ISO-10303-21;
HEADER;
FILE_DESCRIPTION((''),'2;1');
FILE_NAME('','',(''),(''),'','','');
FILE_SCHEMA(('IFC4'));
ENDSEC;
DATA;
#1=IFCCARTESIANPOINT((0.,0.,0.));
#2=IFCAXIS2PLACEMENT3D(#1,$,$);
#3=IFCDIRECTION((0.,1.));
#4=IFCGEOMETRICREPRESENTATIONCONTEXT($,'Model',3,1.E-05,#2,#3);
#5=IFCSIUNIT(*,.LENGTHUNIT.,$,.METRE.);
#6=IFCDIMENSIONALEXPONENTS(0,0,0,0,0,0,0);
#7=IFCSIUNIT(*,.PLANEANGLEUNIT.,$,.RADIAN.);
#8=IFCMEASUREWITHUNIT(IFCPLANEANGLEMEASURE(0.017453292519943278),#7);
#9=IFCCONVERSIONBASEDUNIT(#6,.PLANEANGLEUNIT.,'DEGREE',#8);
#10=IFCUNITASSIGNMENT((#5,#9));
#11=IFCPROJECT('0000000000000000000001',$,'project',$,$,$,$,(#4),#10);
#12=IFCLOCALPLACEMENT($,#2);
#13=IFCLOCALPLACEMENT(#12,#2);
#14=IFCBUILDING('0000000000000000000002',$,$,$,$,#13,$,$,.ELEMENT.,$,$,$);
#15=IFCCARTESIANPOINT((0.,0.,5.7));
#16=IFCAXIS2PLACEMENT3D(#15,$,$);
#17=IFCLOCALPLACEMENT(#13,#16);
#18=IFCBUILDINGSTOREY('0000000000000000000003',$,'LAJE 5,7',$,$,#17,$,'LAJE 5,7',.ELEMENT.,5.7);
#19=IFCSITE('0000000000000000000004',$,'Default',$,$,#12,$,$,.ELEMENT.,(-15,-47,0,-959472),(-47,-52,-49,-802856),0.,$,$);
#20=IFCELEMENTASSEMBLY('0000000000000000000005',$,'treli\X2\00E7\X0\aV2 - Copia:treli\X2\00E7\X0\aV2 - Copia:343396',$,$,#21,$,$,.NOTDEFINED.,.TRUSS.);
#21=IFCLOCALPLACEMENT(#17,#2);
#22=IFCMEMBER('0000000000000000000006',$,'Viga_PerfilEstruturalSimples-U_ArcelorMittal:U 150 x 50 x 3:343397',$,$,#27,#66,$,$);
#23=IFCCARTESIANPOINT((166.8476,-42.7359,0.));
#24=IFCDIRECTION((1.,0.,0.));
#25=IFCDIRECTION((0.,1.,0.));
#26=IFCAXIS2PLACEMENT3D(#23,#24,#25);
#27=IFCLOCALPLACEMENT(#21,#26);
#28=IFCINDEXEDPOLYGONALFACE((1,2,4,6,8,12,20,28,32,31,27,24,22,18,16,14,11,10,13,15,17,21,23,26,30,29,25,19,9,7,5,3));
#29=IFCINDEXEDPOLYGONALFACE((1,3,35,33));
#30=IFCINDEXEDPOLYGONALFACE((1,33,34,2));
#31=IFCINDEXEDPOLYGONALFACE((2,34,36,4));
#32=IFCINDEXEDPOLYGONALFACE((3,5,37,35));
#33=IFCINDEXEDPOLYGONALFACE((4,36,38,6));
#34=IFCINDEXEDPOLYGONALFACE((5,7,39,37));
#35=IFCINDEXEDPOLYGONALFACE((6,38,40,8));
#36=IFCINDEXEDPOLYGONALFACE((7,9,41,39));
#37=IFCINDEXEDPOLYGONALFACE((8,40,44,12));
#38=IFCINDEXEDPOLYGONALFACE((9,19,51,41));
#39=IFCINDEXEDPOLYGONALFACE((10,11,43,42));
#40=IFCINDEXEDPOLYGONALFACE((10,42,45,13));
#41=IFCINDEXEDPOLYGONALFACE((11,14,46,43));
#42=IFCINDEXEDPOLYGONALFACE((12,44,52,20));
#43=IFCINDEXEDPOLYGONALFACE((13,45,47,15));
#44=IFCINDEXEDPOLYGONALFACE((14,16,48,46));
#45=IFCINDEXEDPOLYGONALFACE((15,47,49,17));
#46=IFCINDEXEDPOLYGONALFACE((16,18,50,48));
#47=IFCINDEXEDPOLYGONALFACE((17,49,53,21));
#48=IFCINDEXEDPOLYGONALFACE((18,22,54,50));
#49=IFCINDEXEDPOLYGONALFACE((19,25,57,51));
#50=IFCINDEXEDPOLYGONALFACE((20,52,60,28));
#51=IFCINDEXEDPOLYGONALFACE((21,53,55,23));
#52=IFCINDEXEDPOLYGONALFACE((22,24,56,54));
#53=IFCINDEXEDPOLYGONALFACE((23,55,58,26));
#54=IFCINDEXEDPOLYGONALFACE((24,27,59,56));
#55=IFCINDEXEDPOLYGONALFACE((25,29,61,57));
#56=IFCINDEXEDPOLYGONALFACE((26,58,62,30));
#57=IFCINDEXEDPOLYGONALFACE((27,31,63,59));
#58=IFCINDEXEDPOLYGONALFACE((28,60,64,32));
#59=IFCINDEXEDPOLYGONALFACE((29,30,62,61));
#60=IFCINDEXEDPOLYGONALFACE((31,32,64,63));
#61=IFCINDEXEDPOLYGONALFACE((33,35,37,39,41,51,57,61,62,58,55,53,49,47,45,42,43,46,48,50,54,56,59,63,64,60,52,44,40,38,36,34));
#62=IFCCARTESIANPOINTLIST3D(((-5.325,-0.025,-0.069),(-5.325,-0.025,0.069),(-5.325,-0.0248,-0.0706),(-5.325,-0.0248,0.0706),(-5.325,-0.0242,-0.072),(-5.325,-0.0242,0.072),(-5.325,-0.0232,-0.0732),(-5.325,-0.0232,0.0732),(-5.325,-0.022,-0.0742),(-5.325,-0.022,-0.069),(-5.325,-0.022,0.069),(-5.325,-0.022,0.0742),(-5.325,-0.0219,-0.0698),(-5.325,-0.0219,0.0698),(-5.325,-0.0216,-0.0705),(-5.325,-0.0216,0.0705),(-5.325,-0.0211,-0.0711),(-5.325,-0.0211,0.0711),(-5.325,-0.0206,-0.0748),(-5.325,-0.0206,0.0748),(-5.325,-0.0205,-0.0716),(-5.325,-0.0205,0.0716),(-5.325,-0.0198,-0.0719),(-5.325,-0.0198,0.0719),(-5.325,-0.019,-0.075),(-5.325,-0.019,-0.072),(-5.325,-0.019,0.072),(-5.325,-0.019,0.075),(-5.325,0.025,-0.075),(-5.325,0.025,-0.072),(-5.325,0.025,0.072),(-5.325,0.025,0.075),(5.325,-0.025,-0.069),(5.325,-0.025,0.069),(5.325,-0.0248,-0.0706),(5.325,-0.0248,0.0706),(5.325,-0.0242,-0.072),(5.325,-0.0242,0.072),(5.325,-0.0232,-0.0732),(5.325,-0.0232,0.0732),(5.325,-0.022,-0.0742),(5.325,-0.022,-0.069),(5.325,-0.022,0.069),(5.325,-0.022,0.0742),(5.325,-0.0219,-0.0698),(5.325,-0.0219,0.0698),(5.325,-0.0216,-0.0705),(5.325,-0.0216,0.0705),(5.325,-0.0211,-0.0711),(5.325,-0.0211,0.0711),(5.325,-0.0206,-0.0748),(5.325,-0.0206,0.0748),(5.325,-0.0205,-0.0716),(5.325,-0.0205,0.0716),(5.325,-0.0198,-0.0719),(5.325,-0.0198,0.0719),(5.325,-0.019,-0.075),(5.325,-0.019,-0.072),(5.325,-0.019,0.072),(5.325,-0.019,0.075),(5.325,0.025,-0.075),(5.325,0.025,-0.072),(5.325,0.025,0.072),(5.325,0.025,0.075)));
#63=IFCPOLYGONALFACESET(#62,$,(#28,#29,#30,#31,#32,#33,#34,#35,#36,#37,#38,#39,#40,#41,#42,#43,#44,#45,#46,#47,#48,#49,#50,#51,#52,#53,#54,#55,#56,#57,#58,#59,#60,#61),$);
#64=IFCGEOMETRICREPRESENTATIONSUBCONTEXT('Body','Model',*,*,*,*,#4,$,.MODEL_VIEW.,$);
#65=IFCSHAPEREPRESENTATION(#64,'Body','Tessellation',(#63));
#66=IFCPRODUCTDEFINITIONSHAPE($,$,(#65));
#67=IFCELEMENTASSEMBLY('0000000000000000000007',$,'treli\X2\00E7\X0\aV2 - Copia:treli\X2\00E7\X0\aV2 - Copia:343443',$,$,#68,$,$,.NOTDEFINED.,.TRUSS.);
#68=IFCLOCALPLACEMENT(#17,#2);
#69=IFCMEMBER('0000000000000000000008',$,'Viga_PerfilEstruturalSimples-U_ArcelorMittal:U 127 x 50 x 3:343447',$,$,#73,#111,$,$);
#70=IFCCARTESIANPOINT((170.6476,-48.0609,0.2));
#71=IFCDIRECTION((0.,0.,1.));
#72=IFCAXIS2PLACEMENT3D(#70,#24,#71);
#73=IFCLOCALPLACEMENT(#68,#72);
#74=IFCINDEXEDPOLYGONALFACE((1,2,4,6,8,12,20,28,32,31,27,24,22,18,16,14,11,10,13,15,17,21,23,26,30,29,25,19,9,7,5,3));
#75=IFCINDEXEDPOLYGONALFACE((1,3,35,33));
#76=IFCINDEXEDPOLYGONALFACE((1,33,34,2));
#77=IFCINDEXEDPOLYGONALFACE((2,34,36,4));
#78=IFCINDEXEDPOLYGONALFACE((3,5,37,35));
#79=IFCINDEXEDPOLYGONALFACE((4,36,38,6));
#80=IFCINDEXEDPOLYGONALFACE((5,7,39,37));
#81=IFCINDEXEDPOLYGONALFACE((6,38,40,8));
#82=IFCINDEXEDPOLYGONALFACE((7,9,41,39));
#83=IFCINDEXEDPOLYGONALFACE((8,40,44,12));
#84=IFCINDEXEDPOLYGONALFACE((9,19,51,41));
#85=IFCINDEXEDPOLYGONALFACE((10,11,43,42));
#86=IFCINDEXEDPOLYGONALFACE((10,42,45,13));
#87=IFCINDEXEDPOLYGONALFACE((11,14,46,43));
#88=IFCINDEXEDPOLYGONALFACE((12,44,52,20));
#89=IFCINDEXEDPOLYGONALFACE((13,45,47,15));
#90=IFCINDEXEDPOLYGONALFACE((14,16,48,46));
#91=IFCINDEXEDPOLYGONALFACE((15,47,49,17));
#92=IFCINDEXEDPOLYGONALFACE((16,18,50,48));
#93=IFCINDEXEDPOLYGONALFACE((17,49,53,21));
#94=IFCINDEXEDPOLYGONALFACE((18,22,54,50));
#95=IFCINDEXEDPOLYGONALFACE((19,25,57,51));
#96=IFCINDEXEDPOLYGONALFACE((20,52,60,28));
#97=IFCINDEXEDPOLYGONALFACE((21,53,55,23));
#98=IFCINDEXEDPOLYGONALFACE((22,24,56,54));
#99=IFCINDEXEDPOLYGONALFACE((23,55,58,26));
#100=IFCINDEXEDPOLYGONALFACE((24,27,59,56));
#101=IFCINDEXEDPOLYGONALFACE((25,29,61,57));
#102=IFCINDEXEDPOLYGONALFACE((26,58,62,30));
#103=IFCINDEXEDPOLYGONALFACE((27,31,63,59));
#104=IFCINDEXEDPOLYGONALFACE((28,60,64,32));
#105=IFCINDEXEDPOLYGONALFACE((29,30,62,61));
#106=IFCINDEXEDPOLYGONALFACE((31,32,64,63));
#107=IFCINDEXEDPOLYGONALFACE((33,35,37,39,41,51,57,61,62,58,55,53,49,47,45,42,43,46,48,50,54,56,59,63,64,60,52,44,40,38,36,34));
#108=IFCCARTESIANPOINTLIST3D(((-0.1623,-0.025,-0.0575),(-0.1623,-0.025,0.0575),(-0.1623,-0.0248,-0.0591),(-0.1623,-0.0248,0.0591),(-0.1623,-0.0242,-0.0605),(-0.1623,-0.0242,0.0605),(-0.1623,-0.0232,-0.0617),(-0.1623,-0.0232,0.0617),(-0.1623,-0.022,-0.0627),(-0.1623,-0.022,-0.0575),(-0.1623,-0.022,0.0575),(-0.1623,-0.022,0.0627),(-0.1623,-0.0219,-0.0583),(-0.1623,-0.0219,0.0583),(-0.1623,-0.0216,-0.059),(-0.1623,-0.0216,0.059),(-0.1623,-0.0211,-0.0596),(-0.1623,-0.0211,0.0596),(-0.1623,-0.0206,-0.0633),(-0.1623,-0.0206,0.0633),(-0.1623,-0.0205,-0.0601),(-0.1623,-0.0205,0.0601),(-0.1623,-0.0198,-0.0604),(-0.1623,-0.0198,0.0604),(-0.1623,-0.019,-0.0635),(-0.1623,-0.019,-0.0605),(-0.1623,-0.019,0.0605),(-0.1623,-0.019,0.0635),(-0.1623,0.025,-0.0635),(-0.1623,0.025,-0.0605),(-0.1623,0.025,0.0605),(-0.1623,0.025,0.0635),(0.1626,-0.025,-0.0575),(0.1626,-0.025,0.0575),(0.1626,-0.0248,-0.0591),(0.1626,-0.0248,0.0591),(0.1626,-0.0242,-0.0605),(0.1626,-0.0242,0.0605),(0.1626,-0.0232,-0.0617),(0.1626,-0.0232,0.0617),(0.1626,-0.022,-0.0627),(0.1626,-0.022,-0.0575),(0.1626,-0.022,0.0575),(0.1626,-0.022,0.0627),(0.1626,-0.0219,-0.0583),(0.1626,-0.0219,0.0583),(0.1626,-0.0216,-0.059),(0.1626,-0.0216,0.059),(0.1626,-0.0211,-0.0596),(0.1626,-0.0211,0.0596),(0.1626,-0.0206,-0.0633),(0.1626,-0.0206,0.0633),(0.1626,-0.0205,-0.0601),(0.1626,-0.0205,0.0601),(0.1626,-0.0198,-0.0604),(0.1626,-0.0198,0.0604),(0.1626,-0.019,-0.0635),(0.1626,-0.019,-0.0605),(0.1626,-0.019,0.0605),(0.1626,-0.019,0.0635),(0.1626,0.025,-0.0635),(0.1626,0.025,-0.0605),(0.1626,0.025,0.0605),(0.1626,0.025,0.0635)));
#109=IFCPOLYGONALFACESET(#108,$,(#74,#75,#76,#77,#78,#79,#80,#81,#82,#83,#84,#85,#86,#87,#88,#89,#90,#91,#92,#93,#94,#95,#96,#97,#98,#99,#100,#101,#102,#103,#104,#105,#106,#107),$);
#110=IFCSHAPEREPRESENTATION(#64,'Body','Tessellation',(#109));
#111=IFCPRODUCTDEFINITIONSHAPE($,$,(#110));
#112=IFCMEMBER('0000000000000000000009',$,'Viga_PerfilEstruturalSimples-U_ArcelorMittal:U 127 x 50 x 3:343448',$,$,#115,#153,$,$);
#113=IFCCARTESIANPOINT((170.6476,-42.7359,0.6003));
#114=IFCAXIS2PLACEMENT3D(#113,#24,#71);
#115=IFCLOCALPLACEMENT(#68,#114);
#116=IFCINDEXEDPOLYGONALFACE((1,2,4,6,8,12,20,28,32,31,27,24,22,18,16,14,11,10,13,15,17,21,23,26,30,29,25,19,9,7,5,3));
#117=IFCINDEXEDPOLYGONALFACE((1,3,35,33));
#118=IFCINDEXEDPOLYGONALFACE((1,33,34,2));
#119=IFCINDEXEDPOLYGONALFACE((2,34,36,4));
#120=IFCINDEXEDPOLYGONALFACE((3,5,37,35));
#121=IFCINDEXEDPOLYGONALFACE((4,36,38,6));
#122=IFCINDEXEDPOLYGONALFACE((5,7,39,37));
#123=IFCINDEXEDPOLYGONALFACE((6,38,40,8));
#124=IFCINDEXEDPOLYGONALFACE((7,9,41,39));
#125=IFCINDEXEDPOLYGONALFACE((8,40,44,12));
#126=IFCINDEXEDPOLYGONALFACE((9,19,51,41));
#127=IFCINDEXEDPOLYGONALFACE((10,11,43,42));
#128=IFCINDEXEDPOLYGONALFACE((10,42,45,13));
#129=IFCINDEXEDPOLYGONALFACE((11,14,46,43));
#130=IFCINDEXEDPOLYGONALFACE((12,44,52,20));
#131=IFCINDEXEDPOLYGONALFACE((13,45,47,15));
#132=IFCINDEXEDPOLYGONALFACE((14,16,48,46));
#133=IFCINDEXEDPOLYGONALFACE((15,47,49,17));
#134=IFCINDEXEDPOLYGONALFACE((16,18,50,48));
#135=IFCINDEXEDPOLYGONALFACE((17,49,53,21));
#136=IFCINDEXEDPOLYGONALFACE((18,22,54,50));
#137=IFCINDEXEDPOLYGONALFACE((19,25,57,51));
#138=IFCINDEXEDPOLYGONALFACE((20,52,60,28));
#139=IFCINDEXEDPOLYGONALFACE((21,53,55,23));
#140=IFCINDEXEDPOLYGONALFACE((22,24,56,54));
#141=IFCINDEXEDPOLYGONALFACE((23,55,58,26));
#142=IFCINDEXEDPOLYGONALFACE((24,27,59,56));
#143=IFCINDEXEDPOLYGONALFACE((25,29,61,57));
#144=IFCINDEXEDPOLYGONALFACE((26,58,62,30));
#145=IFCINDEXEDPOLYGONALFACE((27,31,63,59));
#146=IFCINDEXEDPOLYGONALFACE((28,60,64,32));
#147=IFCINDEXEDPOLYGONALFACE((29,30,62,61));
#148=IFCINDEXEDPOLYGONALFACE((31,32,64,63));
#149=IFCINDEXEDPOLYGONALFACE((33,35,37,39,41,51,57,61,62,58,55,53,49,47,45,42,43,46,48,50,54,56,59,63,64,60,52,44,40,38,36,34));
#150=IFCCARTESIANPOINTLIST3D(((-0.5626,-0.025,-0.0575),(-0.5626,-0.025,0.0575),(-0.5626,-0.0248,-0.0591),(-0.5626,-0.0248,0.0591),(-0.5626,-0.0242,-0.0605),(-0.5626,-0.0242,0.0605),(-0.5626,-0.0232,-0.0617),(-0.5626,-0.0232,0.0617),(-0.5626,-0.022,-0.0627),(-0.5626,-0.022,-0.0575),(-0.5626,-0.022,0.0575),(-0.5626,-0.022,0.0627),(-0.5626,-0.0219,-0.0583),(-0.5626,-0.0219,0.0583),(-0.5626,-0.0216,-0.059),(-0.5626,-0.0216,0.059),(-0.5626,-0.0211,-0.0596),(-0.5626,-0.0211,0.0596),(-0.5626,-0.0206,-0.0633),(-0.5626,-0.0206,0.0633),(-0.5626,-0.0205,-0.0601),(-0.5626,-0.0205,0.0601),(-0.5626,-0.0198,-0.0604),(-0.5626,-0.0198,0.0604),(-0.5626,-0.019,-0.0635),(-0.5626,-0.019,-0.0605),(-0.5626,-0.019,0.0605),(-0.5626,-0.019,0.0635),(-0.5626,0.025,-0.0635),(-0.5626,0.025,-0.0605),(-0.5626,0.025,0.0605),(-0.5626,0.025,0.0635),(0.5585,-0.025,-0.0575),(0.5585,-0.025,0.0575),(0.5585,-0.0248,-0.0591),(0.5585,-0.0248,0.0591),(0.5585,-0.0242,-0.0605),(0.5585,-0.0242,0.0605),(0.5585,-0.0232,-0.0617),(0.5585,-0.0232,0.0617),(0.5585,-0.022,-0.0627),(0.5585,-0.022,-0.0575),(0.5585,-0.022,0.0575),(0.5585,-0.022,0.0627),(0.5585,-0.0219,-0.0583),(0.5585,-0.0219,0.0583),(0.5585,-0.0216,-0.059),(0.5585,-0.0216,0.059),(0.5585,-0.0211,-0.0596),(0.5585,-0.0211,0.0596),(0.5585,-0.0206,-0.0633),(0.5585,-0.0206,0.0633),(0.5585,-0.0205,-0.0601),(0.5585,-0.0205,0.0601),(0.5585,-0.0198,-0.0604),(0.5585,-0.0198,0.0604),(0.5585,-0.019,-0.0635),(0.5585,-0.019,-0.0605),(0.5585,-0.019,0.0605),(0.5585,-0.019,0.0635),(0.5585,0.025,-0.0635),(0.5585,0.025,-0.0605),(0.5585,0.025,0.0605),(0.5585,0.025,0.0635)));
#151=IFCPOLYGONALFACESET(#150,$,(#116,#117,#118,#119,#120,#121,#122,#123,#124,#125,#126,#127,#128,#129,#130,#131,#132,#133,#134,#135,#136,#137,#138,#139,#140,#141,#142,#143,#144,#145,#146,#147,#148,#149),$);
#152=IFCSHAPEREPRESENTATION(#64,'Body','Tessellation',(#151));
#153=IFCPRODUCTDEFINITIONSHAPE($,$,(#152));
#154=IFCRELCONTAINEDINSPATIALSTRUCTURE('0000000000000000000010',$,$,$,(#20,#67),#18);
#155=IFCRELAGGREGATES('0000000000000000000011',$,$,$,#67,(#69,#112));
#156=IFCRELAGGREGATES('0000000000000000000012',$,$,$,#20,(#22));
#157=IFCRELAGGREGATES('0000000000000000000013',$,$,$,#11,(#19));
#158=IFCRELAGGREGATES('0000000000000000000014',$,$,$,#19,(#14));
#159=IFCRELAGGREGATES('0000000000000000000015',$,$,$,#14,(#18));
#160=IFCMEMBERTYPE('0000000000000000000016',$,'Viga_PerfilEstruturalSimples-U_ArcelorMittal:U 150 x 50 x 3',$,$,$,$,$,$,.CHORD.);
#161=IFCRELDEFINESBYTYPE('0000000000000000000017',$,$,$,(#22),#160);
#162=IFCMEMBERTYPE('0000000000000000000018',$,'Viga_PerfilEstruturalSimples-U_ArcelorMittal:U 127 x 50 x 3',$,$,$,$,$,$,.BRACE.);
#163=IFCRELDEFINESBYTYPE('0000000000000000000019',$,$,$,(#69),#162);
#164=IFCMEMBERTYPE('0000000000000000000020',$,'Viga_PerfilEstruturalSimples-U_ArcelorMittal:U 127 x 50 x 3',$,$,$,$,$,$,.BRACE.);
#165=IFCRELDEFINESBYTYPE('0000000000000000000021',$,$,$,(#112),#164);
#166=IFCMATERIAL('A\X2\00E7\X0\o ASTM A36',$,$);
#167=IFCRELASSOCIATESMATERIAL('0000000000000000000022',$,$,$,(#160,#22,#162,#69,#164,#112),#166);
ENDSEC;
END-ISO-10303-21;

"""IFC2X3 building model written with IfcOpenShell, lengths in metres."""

from ifc_helpers import new_model, entity, si_unit, converted_unit, direction, frame, frame_2d, origin, place, context, subcontext, project, spatial, polyline, circle_curve, parameter, trimmed, segment, composite_curve, outline, extrude, source, transform, mapped, material, type_object, type_shapes, element, aggregate, save


model = new_model("IFC2X3")

# Units and contexts
model_context = context("Model", 3, precision=1e-05, world=origin(), true_north=direction((0.0, 1.0)))
body_context = subcontext(model_context, "Body", "Model", "MODEL_VIEW")
ifc_project = project(units=[si_unit("LENGTHUNIT", "METRE"), converted_unit("PLANEANGLEUNIT", "DEGREE", entity("IfcPlaneAngleMeasure", 0.017453292519943278), si_unit("PLANEANGLEUNIT", "RADIAN"), dimensions=[0, 0, 0, 0, 0, 0, 0])], contexts=[model_context])

# Site, building, storey
site_placement = place(None, origin())
site = spatial("IfcSite", under=ifc_project, at=site_placement, Name="Default", CompositionType="ELEMENT", RefLatitude=(-15, -47, 0, -959472), RefLongitude=(-47, -52, -49, -802856), RefElevation=0.0)
building_placement = place(site_placement, origin())
building = spatial("IfcBuilding", under=site, at=building_placement, CompositionType="ELEMENT")
storey_placement = place(building_placement, frame((0.0, 0.0, 5.7)))
storey = spatial("IfcBuildingStorey", under=building, at=storey_placement, Name="LAJE 5,7", LongName="LAJE 5,7", CompositionType="ELEMENT", Elevation=5.7)

# Element assemblies, member
assembly_1_placement = place(storey_placement, origin())
assembly_1 = element("IfcElementAssembly", 1, at=assembly_1_placement, inside=storey, Name="treliçaV2 - Copia:treliçaV2 - Copia:343396", AssemblyPlace="NOTDEFINED", PredefinedType="TRUSS")
ifc_material = material(Name="Aço ASTM A36")
member_type_1 = type_object("IfcMemberType", Name="Viga_PerfilEstruturalSimples-U_ArcelorMittal:U 150 x 50 x 3", PredefinedType="CHORD", material=ifc_material)
shared_shape_1 = source(origin(), body_context, "Body", "SweptSolid", [
    extrude(outline(composite_curve([segment(polyline([(-0.069, -0.0192), (0.069, -0.0192)]), True, "CONTINUOUS"), segment(trimmed(circle_curve(frame_2d((0.069, -0.0132), x_axis=(0.0, 1.0)), 0.006), [parameter(180.0)], [parameter(270.0)], True, "PARAMETER"), True, "CONTINUOUS"), segment(polyline([(0.075, -0.0132), (0.075, 0.0308)]), True, "CONTINUOUS"), segment(polyline([(0.075, 0.0308), (0.072, 0.0308)]), True, "CONTINUOUS"), segment(polyline([(0.072, 0.0308), (0.072, -0.0132)]), True, "CONTINUOUS"), segment(trimmed(circle_curve(frame_2d((0.069, -0.0132), x_axis=(0.0, 1.0)), 0.003), [parameter(180.0)], [parameter(270.0)], True, "PARAMETER"), False, "CONTINUOUS"), segment(polyline([(0.069, -0.0162), (-0.069, -0.0162)]), True, "CONTINUOUS"), segment(trimmed(circle_curve(frame_2d((-0.069, -0.0132), x_axis=(0.0, 1.0)), 0.003), [parameter(90.0)], [parameter(180.0)], True, "PARAMETER"), False, "CONTINUOUS"), segment(polyline([(-0.072, -0.0132), (-0.072, 0.0308)]), True, "CONTINUOUS"), segment(polyline([(-0.072, 0.0308), (-0.075, 0.0308)]), True, "CONTINUOUS"), segment(polyline([(-0.075, 0.0308), (-0.075, -0.0132)]), True, "CONTINUOUS"), segment(trimmed(circle_curve(frame_2d((-0.069, -0.0132), x_axis=(0.0, 1.0)), 0.006), [parameter(90.0)], [parameter(180.0)], True, "PARAMETER"), True, "CONTINUOUS")], self_intersect=False)), frame((-5.325, -0.0058, 0.0), z_axis=(1.0, 0.0, 0.0), x_axis=(0.0, 0.0, -1.0)), (0.0, 0.0, 1.0), 10.65),
])
type_shapes(member_type_1, [shared_shape_1])
member_1_placement = place(assembly_1_placement, frame((166.8476, -42.7359, 0.0), z_axis=(1.0, 0.0, 0.0), x_axis=(0.0, 1.0, 0.0)))
member_1 = element("IfcMember", 2, at=member_1_placement, type_object=member_type_1, material=ifc_material, Name="Viga_PerfilEstruturalSimples-U_ArcelorMittal:U 150 x 50 x 3:343397", context=body_context, shape_type="MappedRepresentation", body=[
    mapped(shared_shape_1, transform((0.0, 0.0, 0.0), scale=1.0)),
])
assembly_2_placement = place(storey_placement, origin())
assembly_2 = element("IfcElementAssembly", 3, at=assembly_2_placement, inside=storey, Name="treliçaV2 - Copia:treliçaV2 - Copia:343443", AssemblyPlace="NOTDEFINED", PredefinedType="TRUSS")

# Members
member_type_2 = type_object("IfcMemberType", Name="Viga_PerfilEstruturalSimples-U_ArcelorMittal:U 127 x 50 x 3", PredefinedType="BRACE", material=ifc_material)
shared_shape_2 = source(origin(), body_context, "Body", "SweptSolid", [
    extrude(outline(composite_curve([segment(polyline([(-0.0575, -0.0192), (0.0575, -0.0192)]), True, "CONTINUOUS"), segment(trimmed(circle_curve(frame_2d((0.0575, -0.0132), x_axis=(0.0, 1.0)), 0.006), [parameter(180.0)], [parameter(270.0)], True, "PARAMETER"), True, "CONTINUOUS"), segment(polyline([(0.0635, -0.0132), (0.0635, 0.0308)]), True, "CONTINUOUS"), segment(polyline([(0.0635, 0.0308), (0.0605, 0.0308)]), True, "CONTINUOUS"), segment(polyline([(0.0605, 0.0308), (0.0605, -0.0132)]), True, "CONTINUOUS"), segment(trimmed(circle_curve(frame_2d((0.0575, -0.0132), x_axis=(0.0, 1.0)), 0.003), [parameter(180.0)], [parameter(270.0)], True, "PARAMETER"), False, "CONTINUOUS"), segment(polyline([(0.0575, -0.0162), (-0.0575, -0.0162)]), True, "CONTINUOUS"), segment(trimmed(circle_curve(frame_2d((-0.0575, -0.0132), x_axis=(0.0, 1.0)), 0.003), [parameter(90.0)], [parameter(180.0)], True, "PARAMETER"), False, "CONTINUOUS"), segment(polyline([(-0.0605, -0.0132), (-0.0605, 0.0308)]), True, "CONTINUOUS"), segment(polyline([(-0.0605, 0.0308), (-0.0635, 0.0308)]), True, "CONTINUOUS"), segment(polyline([(-0.0635, 0.0308), (-0.0635, -0.0132)]), True, "CONTINUOUS"), segment(trimmed(circle_curve(frame_2d((-0.0575, -0.0132), x_axis=(0.0, 1.0)), 0.006), [parameter(90.0)], [parameter(180.0)], True, "PARAMETER"), True, "CONTINUOUS")], self_intersect=False)), frame((-0.1623, -0.0058, 0.0), z_axis=(1.0, 0.0, 0.0), x_axis=(0.0, 0.0, -1.0)), (0.0, 0.0, 1.0), 0.3249),
])
type_shapes(member_type_2, [shared_shape_2])
member_2_placement = place(assembly_2_placement, frame((170.6476, -48.0609, 0.2), z_axis=(1.0, 0.0, 0.0), x_axis=(0.0, 0.0, 1.0)))
member_2 = element("IfcMember", 4, at=member_2_placement, type_object=member_type_2, material=ifc_material, Name="Viga_PerfilEstruturalSimples-U_ArcelorMittal:U 127 x 50 x 3:343447", context=body_context, shape_type="MappedRepresentation", body=[
    mapped(shared_shape_2, transform((0.0, 0.0, 0.0), scale=1.0)),
])
member_type_3 = type_object("IfcMemberType", Name="Viga_PerfilEstruturalSimples-U_ArcelorMittal:U 127 x 50 x 3", PredefinedType="BRACE", material=ifc_material)
shared_shape_3 = source(origin(), body_context, "Body", "SweptSolid", [
    extrude(outline(composite_curve([segment(polyline([(-0.0575, -0.0192), (0.0575, -0.0192)]), True, "CONTINUOUS"), segment(trimmed(circle_curve(frame_2d((0.0575, -0.0132), x_axis=(0.0, 1.0)), 0.006), [parameter(180.0)], [parameter(270.0)], True, "PARAMETER"), True, "CONTINUOUS"), segment(polyline([(0.0635, -0.0132), (0.0635, 0.0308)]), True, "CONTINUOUS"), segment(polyline([(0.0635, 0.0308), (0.0605, 0.0308)]), True, "CONTINUOUS"), segment(polyline([(0.0605, 0.0308), (0.0605, -0.0132)]), True, "CONTINUOUS"), segment(trimmed(circle_curve(frame_2d((0.0575, -0.0132), x_axis=(0.0, 1.0)), 0.003), [parameter(180.0)], [parameter(270.0)], True, "PARAMETER"), False, "CONTINUOUS"), segment(polyline([(0.0575, -0.0162), (-0.0575, -0.0162)]), True, "CONTINUOUS"), segment(trimmed(circle_curve(frame_2d((-0.0575, -0.0132), x_axis=(0.0, 1.0)), 0.003), [parameter(90.0)], [parameter(180.0)], True, "PARAMETER"), False, "CONTINUOUS"), segment(polyline([(-0.0605, -0.0132), (-0.0605, 0.0308)]), True, "CONTINUOUS"), segment(polyline([(-0.0605, 0.0308), (-0.0635, 0.0308)]), True, "CONTINUOUS"), segment(polyline([(-0.0635, 0.0308), (-0.0635, -0.0132)]), True, "CONTINUOUS"), segment(trimmed(circle_curve(frame_2d((-0.0575, -0.0132), x_axis=(0.0, 1.0)), 0.006), [parameter(90.0)], [parameter(180.0)], True, "PARAMETER"), True, "CONTINUOUS")], self_intersect=False)), frame((-0.5626, -0.0058, 0.0), z_axis=(1.0, 0.0, 0.0), x_axis=(0.0, 0.0, -1.0)), (0.0, 0.0, 1.0), 1.1211),
])
type_shapes(member_type_3, [shared_shape_3])
member_3_placement = place(assembly_2_placement, frame((170.6476, -42.7359, 0.6003), z_axis=(1.0, 0.0, 0.0), x_axis=(0.0, 0.0, 1.0)))
member_3 = element("IfcMember", 5, at=member_3_placement, type_object=member_type_3, material=ifc_material, Name="Viga_PerfilEstruturalSimples-U_ArcelorMittal:U 127 x 50 x 3:343448", context=body_context, shape_type="MappedRepresentation", body=[
    mapped(shared_shape_3, transform((0.0, 0.0, 0.0), scale=1.0)),
])
aggregate(assembly_2, [member_2, member_3])
aggregate(assembly_1, [member_1])

save(model, "model.ifc")
